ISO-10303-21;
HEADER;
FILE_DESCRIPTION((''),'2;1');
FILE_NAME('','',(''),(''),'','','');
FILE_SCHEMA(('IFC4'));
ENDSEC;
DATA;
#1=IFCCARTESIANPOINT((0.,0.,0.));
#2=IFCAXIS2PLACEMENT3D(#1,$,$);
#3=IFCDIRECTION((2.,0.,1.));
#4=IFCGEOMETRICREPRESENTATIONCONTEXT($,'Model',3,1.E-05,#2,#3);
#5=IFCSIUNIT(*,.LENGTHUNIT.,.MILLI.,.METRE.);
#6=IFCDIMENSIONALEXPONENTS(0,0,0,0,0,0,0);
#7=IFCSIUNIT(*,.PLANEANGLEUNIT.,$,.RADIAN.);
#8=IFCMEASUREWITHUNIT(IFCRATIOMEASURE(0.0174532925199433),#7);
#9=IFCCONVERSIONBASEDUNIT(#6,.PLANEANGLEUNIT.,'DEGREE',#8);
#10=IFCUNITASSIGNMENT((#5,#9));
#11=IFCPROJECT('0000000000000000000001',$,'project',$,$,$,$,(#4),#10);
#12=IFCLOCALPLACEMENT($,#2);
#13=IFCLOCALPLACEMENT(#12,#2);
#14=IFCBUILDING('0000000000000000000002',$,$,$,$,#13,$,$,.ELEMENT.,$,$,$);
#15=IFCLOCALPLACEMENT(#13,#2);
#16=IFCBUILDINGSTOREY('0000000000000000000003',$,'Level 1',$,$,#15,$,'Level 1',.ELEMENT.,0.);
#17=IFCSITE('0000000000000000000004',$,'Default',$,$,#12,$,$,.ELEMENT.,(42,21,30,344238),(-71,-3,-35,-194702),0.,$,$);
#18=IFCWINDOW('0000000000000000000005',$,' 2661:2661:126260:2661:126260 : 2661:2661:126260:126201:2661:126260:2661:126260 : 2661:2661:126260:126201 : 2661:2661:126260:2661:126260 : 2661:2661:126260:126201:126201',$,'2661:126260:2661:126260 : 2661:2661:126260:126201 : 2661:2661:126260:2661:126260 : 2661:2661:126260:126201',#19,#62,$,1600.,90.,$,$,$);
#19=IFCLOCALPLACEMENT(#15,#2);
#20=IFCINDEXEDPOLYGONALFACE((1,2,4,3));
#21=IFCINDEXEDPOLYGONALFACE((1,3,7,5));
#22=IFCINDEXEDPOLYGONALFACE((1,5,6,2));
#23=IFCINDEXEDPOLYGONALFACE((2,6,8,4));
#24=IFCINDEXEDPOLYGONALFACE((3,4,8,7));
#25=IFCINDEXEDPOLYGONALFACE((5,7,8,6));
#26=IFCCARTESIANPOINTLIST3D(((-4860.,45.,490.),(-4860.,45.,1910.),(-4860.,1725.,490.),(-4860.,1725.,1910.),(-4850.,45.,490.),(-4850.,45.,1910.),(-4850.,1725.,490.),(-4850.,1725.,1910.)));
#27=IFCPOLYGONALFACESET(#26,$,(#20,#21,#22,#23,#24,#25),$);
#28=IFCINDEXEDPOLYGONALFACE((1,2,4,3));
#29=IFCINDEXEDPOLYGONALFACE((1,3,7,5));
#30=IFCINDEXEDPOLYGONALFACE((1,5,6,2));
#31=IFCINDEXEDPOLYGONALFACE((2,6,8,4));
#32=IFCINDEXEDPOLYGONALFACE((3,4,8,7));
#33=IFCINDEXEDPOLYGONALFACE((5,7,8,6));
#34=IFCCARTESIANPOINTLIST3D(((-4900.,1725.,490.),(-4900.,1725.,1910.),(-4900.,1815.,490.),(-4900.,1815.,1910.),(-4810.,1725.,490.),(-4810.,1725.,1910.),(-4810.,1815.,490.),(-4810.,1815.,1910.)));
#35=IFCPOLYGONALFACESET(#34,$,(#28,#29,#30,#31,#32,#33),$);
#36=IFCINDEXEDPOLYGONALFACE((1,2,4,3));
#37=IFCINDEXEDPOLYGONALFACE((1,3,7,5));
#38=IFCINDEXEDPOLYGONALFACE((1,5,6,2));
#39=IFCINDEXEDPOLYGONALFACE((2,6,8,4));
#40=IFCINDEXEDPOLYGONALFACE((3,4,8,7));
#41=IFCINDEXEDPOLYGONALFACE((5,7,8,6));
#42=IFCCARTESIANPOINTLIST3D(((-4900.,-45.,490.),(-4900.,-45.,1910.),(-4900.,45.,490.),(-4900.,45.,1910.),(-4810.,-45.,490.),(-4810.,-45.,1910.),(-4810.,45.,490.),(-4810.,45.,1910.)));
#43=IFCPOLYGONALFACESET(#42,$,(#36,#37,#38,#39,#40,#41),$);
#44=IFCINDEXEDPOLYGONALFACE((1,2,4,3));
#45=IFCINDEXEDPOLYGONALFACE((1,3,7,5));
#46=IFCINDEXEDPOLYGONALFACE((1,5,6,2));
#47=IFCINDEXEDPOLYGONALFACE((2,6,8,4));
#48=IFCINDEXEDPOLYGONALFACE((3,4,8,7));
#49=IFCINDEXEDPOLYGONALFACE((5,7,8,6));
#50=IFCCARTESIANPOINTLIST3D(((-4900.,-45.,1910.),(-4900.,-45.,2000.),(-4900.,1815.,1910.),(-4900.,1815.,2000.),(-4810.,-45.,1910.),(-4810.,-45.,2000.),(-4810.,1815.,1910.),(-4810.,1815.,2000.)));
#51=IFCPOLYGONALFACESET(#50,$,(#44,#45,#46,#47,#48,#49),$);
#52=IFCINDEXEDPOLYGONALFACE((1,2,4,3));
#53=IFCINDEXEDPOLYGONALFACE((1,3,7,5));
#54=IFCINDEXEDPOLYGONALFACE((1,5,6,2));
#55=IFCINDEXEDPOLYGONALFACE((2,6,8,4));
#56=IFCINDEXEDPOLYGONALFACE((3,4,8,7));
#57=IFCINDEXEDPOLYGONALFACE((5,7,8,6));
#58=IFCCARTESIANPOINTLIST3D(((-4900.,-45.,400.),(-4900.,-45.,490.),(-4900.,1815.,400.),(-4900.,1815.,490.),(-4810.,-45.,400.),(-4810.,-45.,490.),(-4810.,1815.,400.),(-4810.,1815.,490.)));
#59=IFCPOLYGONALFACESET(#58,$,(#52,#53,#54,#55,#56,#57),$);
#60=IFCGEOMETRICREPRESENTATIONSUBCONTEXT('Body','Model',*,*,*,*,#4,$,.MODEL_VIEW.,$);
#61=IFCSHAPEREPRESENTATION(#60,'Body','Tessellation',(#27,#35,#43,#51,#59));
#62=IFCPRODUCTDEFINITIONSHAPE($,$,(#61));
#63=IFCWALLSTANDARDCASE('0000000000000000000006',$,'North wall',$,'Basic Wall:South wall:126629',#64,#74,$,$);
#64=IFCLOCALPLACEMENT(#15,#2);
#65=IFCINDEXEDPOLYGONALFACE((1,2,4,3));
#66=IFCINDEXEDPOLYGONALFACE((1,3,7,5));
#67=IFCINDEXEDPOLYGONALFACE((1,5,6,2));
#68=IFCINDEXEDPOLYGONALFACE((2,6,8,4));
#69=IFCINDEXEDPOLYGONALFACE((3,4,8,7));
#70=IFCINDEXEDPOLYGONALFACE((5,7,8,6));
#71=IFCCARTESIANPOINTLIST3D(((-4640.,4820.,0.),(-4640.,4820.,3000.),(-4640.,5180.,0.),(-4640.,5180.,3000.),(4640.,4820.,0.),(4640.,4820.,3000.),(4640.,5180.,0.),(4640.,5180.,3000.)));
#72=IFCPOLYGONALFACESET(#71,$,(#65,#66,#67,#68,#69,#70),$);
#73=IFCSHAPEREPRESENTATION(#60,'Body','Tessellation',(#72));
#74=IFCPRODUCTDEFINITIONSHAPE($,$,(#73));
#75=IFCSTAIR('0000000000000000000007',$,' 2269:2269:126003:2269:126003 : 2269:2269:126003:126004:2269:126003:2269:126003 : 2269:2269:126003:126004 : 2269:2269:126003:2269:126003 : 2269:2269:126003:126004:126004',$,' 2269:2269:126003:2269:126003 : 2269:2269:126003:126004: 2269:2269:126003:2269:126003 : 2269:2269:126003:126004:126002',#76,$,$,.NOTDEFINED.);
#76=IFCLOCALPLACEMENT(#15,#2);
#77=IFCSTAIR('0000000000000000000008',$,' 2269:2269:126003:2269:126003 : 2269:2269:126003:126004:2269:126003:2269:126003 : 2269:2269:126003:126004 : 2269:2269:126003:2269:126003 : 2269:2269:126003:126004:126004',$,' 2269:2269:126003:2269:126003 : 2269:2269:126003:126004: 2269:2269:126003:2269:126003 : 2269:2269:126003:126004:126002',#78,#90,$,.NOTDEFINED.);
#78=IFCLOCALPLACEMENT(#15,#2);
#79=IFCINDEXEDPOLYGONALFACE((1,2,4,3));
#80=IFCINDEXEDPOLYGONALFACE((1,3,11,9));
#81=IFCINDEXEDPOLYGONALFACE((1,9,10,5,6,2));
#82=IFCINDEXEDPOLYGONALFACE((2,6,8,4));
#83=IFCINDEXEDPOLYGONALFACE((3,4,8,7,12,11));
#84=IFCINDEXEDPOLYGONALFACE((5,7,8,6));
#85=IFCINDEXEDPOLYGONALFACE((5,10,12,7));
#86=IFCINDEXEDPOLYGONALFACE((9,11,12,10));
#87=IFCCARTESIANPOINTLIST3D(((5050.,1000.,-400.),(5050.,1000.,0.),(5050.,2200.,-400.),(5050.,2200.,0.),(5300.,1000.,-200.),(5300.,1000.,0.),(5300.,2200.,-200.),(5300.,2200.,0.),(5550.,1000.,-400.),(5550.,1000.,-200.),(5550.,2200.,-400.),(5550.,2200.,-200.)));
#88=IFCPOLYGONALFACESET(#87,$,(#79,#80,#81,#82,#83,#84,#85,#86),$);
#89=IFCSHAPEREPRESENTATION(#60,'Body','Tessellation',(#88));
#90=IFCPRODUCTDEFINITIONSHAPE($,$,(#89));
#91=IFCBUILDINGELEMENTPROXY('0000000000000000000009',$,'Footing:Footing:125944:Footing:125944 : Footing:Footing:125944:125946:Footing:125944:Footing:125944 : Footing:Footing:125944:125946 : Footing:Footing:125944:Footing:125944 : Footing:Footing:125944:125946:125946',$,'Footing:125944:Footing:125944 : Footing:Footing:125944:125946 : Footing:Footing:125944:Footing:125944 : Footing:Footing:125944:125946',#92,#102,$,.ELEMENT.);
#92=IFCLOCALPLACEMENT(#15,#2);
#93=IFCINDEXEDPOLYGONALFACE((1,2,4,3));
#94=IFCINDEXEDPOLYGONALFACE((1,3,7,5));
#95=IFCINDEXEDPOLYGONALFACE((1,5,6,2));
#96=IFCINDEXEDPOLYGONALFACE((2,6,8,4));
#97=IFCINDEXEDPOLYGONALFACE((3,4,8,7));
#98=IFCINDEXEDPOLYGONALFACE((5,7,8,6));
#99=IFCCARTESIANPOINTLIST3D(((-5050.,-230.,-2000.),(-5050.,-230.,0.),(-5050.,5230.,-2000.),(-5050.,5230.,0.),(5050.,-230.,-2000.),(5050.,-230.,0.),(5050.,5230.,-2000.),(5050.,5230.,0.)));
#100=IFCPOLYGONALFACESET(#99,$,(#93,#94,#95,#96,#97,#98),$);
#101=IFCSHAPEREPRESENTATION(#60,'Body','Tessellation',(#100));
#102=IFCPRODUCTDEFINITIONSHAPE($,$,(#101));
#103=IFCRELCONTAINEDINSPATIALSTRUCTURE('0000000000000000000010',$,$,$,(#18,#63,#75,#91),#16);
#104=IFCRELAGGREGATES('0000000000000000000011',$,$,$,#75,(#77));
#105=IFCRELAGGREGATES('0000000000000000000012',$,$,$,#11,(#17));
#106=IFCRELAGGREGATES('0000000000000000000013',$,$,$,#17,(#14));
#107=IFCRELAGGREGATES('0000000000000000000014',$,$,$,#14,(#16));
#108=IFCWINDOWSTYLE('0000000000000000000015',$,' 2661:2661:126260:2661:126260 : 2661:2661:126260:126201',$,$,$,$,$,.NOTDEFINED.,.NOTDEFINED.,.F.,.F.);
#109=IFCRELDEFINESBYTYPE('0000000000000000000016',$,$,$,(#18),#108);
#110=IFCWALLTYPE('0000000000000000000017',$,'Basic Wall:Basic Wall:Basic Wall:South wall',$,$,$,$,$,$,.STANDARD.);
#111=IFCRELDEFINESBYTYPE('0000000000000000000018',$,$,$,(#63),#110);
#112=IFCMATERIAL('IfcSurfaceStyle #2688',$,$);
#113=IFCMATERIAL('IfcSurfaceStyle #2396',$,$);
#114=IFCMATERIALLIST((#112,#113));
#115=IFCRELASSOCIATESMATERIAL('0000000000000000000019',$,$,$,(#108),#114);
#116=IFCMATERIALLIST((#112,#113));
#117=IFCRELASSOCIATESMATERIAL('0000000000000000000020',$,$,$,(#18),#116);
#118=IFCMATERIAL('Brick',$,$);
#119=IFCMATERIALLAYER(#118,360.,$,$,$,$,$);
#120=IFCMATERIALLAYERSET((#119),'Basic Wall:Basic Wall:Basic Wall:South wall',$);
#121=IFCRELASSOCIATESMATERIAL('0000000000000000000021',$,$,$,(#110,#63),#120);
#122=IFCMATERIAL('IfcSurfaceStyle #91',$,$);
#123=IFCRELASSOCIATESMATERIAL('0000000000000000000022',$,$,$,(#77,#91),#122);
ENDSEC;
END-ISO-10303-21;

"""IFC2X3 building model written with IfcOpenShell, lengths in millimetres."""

from ifc_helpers import new_model, entity, si_unit, converted_unit, direction, frame, frame_2d, origin, origin_2d_with_axis, place, context, subcontext, project, spatial, polyline, rectangle, outline, extrude, source, transform, mapped, material, material_list, layer, layer_set, layer_usage, type_object, type_shapes, element, aggregate, save


model = new_model("IFC2X3")

# Units and contexts
model_context = context("Model", 3, precision=1e-05, world=origin(), true_north=direction((2.0, 0.0, 1.0)))
body_context = subcontext(model_context, "Body", "Model", "MODEL_VIEW")
ifc_project = project(units=[si_unit("LENGTHUNIT", "METRE", prefix="MILLI"), converted_unit("PLANEANGLEUNIT", "DEGREE", entity("IfcRatioMeasure", 0.0174532925199433), si_unit("PLANEANGLEUNIT", "RADIAN"), dimensions=[0, 0, 0, 0, 0, 0, 0])], contexts=[model_context])

# Site, building, storey
site_placement = place(None, origin())
site = spatial("IfcSite", under=ifc_project, at=site_placement, Name="Default", CompositionType="ELEMENT", RefLatitude=(42, 21, 30, 344238), RefLongitude=(-71, -3, -35, -194702), RefElevation=0.0)
building_placement = place(site_placement, origin())
building = spatial("IfcBuilding", under=site, at=building_placement, CompositionType="ELEMENT")
storey_placement = place(building_placement, origin())
storey = spatial("IfcBuildingStorey", under=building, at=storey_placement, Name="Level 1", LongName="Level 1", CompositionType="ELEMENT", Elevation=0.0)

# Window
ifc_material_1 = material(Name="IfcSurfaceStyle #2396")
ifc_material_2 = material(Name="IfcSurfaceStyle #2688")
ifc_material_list_1 = material_list([ifc_material_2, ifc_material_1])
ifc_material_list_2 = material_list([ifc_material_2, ifc_material_1])
window_style_1 = type_object("IfcWindowStyle", Name=" 2661:2661:126260:2661:126260 : 2661:2661:126260:126201", ConstructionType="NOTDEFINED", OperationType="NOTDEFINED", ParameterTakesPrecedence=False, Sizeable=False, material=ifc_material_list_2)
shared_shape_1 = source(origin(), body_context, "Body", "SweptSolid", [
    extrude(rectangle(XDim=10.0, YDim=1680.0, at=origin_2d_with_axis()), frame((-4855.0, 885.0, 490.0)), (0.0, 0.0, 1.0), 1420.0),
    extrude(rectangle(XDim=90.0, YDim=90.0, at=frame_2d((0.0, 0.0), x_axis=(1.0, 0.0))), frame((-4855.0, 1770.0, 490.0)), (0.0, 0.0, 1.0), 1420.0),
    extrude(rectangle(XDim=90.0, YDim=90.0, at=frame_2d((0.0, 0.0), x_axis=(1.0, 0.0))), frame((-4855.0, 0.0, 490.0)), (0.0, 0.0, 1.0), 1420.0),
    extrude(rectangle(XDim=90.0, YDim=1860.0, at=frame_2d((0.0, 0.0), x_axis=(1.0, 0.0))), frame((-4855.0, 885.0, 1910.0)), (0.0, 0.0, 1.0), 90.0),
    extrude(rectangle(XDim=90.0, YDim=1860.0, at=frame_2d((0.0, 0.0), x_axis=(1.0, 0.0))), frame((-4855.0, 885.0, 400.0)), (0.0, 0.0, 1.0), 90.0),
])
type_shapes(window_style_1, [shared_shape_1])
window_1_placement = place(storey_placement, origin())
element("IfcWindow", 1, at=window_1_placement, inside=storey, type_object=window_style_1, material=ifc_material_list_1, Name=" 2661:2661:126260:2661:126260 : 2661:2661:126260:126201:2661:126260:2661:126260 : 2661:2661:126260:126201 : 2661:2661:126260:2661:126260 : 2661:2661:126260:126201:126201", ObjectType="2661:126260:2661:126260 : 2661:2661:126260:126201 : 2661:2661:126260:2661:126260 : 2661:2661:126260:126201", OverallHeight=1600.0, OverallWidth=90.0, context=body_context, shape_type="MappedRepresentation", body=[
    mapped(shared_shape_1, transform((0.0, 0.0, 0.0), scale=1.0)),
])

# Shared definitions
ifc_material_3 = material(Name="Brick")
ifc_layer = layer(ifc_material_3, 360.0)
ifc_layer_set = layer_set([ifc_layer], Name="Basic Wall:Basic Wall:Basic Wall:South wall")
wall_type = type_object("IfcWallType", Name="Basic Wall:Basic Wall:Basic Wall:South wall", PredefinedType="STANDARD", material=ifc_layer_set)

# Wall
ifc_layer_usage_1 = layer_usage(ifc_layer_set, "AXIS2", "NEGATIVE", 180.0)
wall_1_placement = place(storey_placement, frame((4640.0, 5000.0, 0.0), z_axis=(0.0, 0.0, 1.0), x_axis=(-1.0, 0.0, 0.0)))
element("IfcWallStandardCase", 2, at=wall_1_placement, inside=storey, type_object=wall_type, material=ifc_layer_usage_1, Name="North wall", ObjectType="Basic Wall:South wall:126629", context=body_context, shape_type="SweptSolid", body=[
    extrude(rectangle(XDim=9280.0, YDim=360.0, at=frame_2d((4640.0, 0.0), x_axis=(-1.0, 0.0))), origin(), (0.0, 0.0, 1.0), 3000.0),
])

# Stairs
stair_1_placement = place(storey_placement, frame((5050.0, 1000.0, -400.0)))
stair_1 = element("IfcStair", 3, at=stair_1_placement, inside=storey, Name=" 2269:2269:126003:2269:126003 : 2269:2269:126003:126004:2269:126003:2269:126003 : 2269:2269:126003:126004 : 2269:2269:126003:2269:126003 : 2269:2269:126003:126004:126004", ObjectType=" 2269:2269:126003:2269:126003 : 2269:2269:126003:126004: 2269:2269:126003:2269:126003 : 2269:2269:126003:126004:126002", ShapeType="NOTDEFINED")
ifc_material_4 = material(Name="IfcSurfaceStyle #91")
stair_2_placement = place(stair_1_placement, origin())
stair_2 = element("IfcStair", 4, at=stair_2_placement, material=ifc_material_4, Name=" 2269:2269:126003:2269:126003 : 2269:2269:126003:126004:2269:126003:2269:126003 : 2269:2269:126003:126004 : 2269:2269:126003:2269:126003 : 2269:2269:126003:126004:126004", ObjectType=" 2269:2269:126003:2269:126003 : 2269:2269:126003:126004: 2269:2269:126003:2269:126003 : 2269:2269:126003:126004:126002", ShapeType="NOTDEFINED", context=body_context, shape_type="SweptSolid", body=[
    extrude(outline(polyline([(0.0, -250.0), (200.0, -250.0), (200.0, 250.0), (-200.0, 250.0), (-200.0, 0.0), (0.0, 0.0), (0.0, -250.0)])), frame((250.0, 0.0, 200.0), z_axis=(0.0, 1.0, 0.0), x_axis=(0.0, 0.0, -1.0)), (0.0, 0.0, 1.0), 1200.0),
])
aggregate(stair_1, [stair_2])

# Building element proxy
shared_shape_2 = source(origin(), body_context, "Body", "SweptSolid", [
    extrude(rectangle(XDim=5460.0, YDim=10100.0, at=origin_2d_with_axis()), frame((0.0, 2500.0, -2000.0), z_axis=(0.0, 0.0, 1.0), x_axis=(0.0, -1.0, 0.0)), (0.0, 0.0, 1.0), 2000.0),
])
proxy_placement = place(storey_placement, origin())
element("IfcBuildingElementProxy", 5, at=proxy_placement, inside=storey, material=ifc_material_4, Name="Footing:Footing:125944:Footing:125944 : Footing:Footing:125944:125946:Footing:125944:Footing:125944 : Footing:Footing:125944:125946 : Footing:Footing:125944:Footing:125944 : Footing:Footing:125944:125946:125946", ObjectType="Footing:125944:Footing:125944 : Footing:Footing:125944:125946 : Footing:Footing:125944:Footing:125944 : Footing:Footing:125944:125946", CompositionType="ELEMENT", context=body_context, shape_type="MappedRepresentation", body=[
    mapped(shared_shape_2, transform((0.0, 0.0, 0.0), scale=1.0)),
])

save(model, "model.ifc")
